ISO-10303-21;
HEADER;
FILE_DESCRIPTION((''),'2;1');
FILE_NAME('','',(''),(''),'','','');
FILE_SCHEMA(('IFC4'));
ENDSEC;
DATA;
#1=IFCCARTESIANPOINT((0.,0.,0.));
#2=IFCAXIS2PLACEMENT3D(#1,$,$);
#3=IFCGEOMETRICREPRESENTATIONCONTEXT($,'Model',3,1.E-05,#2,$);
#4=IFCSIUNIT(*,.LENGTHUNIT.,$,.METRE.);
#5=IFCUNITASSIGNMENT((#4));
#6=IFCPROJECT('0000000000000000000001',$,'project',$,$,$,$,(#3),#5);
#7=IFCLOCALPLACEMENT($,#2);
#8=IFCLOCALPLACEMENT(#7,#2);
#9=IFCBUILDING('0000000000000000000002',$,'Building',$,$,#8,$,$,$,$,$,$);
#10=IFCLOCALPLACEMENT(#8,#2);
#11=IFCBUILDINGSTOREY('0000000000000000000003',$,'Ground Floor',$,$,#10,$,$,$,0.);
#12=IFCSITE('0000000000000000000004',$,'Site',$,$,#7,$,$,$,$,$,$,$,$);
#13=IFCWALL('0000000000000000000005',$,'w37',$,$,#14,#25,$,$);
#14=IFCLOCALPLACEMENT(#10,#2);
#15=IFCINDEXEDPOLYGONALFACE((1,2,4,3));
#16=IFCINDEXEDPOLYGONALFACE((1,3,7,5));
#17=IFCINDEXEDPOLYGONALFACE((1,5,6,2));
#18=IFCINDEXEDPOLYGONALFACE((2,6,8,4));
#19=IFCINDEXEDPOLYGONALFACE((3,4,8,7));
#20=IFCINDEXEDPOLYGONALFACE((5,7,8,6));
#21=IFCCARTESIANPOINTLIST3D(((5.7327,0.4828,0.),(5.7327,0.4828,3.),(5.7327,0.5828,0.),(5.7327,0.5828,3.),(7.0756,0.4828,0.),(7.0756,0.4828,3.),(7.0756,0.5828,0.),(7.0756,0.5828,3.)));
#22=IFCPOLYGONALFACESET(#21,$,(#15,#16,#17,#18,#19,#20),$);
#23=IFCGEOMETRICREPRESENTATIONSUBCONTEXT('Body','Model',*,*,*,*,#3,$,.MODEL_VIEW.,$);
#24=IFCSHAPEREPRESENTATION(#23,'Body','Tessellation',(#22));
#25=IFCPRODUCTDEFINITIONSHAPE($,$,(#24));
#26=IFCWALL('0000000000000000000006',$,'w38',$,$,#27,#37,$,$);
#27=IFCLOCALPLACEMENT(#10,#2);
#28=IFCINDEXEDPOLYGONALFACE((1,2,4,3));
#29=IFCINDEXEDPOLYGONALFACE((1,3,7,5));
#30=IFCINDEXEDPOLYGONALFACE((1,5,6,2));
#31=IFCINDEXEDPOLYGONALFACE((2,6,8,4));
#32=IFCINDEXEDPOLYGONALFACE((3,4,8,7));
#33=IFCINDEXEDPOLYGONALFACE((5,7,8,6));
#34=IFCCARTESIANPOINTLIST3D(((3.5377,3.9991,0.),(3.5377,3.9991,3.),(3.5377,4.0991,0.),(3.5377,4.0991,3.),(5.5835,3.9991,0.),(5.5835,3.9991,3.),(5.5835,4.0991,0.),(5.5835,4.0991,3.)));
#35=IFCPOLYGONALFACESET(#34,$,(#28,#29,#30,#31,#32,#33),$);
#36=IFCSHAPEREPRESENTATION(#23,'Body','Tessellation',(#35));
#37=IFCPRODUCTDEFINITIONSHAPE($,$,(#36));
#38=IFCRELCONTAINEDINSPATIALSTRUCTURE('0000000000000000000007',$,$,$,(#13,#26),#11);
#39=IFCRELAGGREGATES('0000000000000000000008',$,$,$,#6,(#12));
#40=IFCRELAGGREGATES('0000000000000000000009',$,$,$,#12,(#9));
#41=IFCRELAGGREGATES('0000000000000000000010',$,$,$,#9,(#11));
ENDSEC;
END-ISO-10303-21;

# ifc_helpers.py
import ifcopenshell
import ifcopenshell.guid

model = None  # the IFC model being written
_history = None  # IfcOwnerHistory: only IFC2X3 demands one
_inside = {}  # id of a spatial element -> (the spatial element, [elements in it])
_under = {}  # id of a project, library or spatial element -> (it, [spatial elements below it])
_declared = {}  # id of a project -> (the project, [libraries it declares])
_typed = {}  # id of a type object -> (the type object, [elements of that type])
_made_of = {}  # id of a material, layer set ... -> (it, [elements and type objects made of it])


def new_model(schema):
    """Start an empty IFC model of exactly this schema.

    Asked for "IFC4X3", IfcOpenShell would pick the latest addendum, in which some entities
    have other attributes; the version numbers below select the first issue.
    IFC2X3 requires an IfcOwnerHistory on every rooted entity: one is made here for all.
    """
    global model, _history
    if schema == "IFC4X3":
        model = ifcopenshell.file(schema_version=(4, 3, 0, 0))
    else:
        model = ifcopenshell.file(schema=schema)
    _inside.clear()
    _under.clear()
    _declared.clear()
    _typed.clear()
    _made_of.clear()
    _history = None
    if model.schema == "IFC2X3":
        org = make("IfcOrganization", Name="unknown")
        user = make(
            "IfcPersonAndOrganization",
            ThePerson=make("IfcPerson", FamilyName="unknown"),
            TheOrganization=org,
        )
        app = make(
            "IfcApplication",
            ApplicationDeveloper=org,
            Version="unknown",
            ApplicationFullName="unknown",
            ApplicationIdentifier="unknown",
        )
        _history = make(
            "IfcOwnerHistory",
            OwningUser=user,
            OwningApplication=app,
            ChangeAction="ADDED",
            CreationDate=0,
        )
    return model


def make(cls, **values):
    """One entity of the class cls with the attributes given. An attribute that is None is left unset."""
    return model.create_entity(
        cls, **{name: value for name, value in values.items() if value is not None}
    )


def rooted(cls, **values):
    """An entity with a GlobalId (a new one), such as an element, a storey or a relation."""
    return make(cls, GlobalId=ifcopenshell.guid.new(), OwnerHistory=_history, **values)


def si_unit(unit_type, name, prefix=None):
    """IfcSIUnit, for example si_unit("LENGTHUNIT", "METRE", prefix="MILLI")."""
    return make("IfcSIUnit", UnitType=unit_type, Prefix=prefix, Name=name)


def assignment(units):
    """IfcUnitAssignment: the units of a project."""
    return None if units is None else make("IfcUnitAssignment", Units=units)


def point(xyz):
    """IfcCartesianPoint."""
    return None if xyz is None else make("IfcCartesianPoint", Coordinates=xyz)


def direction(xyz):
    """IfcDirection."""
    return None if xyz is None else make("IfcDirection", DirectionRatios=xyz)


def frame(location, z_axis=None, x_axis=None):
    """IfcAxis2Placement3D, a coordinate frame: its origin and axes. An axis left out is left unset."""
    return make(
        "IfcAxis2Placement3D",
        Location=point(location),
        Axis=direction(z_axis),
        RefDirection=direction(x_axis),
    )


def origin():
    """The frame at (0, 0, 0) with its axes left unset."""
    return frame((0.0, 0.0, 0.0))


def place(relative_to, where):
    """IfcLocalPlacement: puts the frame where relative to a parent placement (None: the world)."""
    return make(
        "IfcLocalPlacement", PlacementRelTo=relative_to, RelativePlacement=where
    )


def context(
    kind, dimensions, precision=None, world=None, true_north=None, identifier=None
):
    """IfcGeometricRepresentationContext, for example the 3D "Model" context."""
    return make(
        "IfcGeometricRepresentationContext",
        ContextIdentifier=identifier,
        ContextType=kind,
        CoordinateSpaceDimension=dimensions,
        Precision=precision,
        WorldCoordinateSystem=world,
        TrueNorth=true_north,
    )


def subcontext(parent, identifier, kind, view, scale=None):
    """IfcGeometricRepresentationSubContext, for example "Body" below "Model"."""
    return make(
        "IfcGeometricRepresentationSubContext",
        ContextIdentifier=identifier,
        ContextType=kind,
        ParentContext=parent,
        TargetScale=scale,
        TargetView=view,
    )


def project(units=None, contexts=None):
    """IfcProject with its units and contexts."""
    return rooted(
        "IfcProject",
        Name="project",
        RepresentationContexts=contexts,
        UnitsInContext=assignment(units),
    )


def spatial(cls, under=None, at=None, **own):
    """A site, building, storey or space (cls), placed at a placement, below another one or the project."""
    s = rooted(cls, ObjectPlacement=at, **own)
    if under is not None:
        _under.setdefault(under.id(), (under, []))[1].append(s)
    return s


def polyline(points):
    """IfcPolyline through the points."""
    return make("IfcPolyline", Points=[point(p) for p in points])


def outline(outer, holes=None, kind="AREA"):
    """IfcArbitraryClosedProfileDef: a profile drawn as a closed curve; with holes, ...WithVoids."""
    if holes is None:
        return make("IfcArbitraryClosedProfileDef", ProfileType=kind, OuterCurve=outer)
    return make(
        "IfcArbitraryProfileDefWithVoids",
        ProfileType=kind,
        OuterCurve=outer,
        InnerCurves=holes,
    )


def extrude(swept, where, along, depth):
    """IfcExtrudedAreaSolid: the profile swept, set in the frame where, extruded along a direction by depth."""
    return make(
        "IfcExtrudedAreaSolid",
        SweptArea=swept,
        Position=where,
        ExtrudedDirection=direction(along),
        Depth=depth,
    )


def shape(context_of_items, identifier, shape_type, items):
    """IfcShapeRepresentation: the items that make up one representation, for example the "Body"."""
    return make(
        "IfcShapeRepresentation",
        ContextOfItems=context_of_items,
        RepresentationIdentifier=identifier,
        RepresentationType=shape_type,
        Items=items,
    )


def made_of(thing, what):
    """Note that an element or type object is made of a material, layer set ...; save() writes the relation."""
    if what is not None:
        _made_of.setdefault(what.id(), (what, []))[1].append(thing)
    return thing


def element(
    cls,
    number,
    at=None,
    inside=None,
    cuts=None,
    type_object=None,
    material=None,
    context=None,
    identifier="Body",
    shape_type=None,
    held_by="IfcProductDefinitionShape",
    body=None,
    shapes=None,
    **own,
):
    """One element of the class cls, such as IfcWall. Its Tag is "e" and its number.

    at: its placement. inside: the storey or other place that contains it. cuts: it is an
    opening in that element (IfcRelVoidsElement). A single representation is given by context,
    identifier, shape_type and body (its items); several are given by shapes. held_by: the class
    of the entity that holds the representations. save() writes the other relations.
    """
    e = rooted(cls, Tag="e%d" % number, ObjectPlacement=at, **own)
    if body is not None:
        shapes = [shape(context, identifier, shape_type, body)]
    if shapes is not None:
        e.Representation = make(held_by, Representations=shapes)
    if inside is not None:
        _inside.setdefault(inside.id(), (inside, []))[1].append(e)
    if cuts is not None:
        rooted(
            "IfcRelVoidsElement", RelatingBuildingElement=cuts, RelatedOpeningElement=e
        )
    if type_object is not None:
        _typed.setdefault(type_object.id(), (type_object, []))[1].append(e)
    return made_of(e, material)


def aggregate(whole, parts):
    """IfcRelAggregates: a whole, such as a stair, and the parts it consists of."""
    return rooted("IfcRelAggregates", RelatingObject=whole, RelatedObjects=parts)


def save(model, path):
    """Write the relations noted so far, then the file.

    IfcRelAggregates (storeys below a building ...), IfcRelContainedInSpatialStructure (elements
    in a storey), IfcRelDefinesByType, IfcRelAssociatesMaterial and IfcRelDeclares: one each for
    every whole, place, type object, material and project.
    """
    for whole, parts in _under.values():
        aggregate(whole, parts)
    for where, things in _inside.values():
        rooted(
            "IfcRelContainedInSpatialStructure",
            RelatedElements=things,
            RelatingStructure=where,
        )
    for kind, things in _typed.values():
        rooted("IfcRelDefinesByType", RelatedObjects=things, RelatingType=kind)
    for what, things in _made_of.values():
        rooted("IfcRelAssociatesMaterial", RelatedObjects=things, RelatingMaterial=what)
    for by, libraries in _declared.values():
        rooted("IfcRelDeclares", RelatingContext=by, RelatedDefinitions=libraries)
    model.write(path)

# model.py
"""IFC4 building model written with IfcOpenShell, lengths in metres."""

from ifc_helpers import new_model, si_unit, frame, origin, place, context, subcontext, project, spatial, polyline, outline, extrude, element, save


model = new_model("IFC4")

# Units and contexts
model_context = context("Model", 3, precision=1e-05, world=origin())
body_context = subcontext(model_context, "Body", "Model", "MODEL_VIEW")
ifc_project = project(units=[si_unit("LENGTHUNIT", "METRE")], contexts=[model_context])

# Site, building, storey
site_placement = place(None, origin())
site = spatial("IfcSite", under=ifc_project, at=site_placement, Name="Site")
building_placement = place(site_placement, origin())
building = spatial("IfcBuilding", under=site, at=building_placement, Name="Building")
storey_placement = place(building_placement, origin())
storey = spatial("IfcBuildingStorey", under=building, at=storey_placement, Name="Ground Floor", Elevation=0.0)

# Walls
wall_1_placement = place(storey_placement, frame((5.7327, 0.5328, 0.0), x_axis=(1.0, 0.0, 0.0)))
element("IfcWall", 1, at=wall_1_placement, inside=storey, Name="w37", context=body_context, shape_type="SweptSolid", body=[
    extrude(outline(polyline([(0.0, -0.05), (1.3429, -0.05), (1.3429, 0.05), (0.0, 0.05), (0.0, -0.05)])), origin(), (0.0, 0.0, 1.0), 3.0),
])
wall_2_placement = place(storey_placement, frame((3.5377, 4.0491, 0.0), x_axis=(1.0, 0.0, 0.0)))
element("IfcWall", 2, at=wall_2_placement, inside=storey, Name="w38", context=body_context, shape_type="SweptSolid", body=[
    extrude(outline(polyline([(0.0, -0.05), (2.0459, -0.05), (2.0459, 0.05), (0.0, 0.05), (0.0, -0.05)])), origin(), (0.0, 0.0, 1.0), 3.0),
])

save(model, "model.ifc")
